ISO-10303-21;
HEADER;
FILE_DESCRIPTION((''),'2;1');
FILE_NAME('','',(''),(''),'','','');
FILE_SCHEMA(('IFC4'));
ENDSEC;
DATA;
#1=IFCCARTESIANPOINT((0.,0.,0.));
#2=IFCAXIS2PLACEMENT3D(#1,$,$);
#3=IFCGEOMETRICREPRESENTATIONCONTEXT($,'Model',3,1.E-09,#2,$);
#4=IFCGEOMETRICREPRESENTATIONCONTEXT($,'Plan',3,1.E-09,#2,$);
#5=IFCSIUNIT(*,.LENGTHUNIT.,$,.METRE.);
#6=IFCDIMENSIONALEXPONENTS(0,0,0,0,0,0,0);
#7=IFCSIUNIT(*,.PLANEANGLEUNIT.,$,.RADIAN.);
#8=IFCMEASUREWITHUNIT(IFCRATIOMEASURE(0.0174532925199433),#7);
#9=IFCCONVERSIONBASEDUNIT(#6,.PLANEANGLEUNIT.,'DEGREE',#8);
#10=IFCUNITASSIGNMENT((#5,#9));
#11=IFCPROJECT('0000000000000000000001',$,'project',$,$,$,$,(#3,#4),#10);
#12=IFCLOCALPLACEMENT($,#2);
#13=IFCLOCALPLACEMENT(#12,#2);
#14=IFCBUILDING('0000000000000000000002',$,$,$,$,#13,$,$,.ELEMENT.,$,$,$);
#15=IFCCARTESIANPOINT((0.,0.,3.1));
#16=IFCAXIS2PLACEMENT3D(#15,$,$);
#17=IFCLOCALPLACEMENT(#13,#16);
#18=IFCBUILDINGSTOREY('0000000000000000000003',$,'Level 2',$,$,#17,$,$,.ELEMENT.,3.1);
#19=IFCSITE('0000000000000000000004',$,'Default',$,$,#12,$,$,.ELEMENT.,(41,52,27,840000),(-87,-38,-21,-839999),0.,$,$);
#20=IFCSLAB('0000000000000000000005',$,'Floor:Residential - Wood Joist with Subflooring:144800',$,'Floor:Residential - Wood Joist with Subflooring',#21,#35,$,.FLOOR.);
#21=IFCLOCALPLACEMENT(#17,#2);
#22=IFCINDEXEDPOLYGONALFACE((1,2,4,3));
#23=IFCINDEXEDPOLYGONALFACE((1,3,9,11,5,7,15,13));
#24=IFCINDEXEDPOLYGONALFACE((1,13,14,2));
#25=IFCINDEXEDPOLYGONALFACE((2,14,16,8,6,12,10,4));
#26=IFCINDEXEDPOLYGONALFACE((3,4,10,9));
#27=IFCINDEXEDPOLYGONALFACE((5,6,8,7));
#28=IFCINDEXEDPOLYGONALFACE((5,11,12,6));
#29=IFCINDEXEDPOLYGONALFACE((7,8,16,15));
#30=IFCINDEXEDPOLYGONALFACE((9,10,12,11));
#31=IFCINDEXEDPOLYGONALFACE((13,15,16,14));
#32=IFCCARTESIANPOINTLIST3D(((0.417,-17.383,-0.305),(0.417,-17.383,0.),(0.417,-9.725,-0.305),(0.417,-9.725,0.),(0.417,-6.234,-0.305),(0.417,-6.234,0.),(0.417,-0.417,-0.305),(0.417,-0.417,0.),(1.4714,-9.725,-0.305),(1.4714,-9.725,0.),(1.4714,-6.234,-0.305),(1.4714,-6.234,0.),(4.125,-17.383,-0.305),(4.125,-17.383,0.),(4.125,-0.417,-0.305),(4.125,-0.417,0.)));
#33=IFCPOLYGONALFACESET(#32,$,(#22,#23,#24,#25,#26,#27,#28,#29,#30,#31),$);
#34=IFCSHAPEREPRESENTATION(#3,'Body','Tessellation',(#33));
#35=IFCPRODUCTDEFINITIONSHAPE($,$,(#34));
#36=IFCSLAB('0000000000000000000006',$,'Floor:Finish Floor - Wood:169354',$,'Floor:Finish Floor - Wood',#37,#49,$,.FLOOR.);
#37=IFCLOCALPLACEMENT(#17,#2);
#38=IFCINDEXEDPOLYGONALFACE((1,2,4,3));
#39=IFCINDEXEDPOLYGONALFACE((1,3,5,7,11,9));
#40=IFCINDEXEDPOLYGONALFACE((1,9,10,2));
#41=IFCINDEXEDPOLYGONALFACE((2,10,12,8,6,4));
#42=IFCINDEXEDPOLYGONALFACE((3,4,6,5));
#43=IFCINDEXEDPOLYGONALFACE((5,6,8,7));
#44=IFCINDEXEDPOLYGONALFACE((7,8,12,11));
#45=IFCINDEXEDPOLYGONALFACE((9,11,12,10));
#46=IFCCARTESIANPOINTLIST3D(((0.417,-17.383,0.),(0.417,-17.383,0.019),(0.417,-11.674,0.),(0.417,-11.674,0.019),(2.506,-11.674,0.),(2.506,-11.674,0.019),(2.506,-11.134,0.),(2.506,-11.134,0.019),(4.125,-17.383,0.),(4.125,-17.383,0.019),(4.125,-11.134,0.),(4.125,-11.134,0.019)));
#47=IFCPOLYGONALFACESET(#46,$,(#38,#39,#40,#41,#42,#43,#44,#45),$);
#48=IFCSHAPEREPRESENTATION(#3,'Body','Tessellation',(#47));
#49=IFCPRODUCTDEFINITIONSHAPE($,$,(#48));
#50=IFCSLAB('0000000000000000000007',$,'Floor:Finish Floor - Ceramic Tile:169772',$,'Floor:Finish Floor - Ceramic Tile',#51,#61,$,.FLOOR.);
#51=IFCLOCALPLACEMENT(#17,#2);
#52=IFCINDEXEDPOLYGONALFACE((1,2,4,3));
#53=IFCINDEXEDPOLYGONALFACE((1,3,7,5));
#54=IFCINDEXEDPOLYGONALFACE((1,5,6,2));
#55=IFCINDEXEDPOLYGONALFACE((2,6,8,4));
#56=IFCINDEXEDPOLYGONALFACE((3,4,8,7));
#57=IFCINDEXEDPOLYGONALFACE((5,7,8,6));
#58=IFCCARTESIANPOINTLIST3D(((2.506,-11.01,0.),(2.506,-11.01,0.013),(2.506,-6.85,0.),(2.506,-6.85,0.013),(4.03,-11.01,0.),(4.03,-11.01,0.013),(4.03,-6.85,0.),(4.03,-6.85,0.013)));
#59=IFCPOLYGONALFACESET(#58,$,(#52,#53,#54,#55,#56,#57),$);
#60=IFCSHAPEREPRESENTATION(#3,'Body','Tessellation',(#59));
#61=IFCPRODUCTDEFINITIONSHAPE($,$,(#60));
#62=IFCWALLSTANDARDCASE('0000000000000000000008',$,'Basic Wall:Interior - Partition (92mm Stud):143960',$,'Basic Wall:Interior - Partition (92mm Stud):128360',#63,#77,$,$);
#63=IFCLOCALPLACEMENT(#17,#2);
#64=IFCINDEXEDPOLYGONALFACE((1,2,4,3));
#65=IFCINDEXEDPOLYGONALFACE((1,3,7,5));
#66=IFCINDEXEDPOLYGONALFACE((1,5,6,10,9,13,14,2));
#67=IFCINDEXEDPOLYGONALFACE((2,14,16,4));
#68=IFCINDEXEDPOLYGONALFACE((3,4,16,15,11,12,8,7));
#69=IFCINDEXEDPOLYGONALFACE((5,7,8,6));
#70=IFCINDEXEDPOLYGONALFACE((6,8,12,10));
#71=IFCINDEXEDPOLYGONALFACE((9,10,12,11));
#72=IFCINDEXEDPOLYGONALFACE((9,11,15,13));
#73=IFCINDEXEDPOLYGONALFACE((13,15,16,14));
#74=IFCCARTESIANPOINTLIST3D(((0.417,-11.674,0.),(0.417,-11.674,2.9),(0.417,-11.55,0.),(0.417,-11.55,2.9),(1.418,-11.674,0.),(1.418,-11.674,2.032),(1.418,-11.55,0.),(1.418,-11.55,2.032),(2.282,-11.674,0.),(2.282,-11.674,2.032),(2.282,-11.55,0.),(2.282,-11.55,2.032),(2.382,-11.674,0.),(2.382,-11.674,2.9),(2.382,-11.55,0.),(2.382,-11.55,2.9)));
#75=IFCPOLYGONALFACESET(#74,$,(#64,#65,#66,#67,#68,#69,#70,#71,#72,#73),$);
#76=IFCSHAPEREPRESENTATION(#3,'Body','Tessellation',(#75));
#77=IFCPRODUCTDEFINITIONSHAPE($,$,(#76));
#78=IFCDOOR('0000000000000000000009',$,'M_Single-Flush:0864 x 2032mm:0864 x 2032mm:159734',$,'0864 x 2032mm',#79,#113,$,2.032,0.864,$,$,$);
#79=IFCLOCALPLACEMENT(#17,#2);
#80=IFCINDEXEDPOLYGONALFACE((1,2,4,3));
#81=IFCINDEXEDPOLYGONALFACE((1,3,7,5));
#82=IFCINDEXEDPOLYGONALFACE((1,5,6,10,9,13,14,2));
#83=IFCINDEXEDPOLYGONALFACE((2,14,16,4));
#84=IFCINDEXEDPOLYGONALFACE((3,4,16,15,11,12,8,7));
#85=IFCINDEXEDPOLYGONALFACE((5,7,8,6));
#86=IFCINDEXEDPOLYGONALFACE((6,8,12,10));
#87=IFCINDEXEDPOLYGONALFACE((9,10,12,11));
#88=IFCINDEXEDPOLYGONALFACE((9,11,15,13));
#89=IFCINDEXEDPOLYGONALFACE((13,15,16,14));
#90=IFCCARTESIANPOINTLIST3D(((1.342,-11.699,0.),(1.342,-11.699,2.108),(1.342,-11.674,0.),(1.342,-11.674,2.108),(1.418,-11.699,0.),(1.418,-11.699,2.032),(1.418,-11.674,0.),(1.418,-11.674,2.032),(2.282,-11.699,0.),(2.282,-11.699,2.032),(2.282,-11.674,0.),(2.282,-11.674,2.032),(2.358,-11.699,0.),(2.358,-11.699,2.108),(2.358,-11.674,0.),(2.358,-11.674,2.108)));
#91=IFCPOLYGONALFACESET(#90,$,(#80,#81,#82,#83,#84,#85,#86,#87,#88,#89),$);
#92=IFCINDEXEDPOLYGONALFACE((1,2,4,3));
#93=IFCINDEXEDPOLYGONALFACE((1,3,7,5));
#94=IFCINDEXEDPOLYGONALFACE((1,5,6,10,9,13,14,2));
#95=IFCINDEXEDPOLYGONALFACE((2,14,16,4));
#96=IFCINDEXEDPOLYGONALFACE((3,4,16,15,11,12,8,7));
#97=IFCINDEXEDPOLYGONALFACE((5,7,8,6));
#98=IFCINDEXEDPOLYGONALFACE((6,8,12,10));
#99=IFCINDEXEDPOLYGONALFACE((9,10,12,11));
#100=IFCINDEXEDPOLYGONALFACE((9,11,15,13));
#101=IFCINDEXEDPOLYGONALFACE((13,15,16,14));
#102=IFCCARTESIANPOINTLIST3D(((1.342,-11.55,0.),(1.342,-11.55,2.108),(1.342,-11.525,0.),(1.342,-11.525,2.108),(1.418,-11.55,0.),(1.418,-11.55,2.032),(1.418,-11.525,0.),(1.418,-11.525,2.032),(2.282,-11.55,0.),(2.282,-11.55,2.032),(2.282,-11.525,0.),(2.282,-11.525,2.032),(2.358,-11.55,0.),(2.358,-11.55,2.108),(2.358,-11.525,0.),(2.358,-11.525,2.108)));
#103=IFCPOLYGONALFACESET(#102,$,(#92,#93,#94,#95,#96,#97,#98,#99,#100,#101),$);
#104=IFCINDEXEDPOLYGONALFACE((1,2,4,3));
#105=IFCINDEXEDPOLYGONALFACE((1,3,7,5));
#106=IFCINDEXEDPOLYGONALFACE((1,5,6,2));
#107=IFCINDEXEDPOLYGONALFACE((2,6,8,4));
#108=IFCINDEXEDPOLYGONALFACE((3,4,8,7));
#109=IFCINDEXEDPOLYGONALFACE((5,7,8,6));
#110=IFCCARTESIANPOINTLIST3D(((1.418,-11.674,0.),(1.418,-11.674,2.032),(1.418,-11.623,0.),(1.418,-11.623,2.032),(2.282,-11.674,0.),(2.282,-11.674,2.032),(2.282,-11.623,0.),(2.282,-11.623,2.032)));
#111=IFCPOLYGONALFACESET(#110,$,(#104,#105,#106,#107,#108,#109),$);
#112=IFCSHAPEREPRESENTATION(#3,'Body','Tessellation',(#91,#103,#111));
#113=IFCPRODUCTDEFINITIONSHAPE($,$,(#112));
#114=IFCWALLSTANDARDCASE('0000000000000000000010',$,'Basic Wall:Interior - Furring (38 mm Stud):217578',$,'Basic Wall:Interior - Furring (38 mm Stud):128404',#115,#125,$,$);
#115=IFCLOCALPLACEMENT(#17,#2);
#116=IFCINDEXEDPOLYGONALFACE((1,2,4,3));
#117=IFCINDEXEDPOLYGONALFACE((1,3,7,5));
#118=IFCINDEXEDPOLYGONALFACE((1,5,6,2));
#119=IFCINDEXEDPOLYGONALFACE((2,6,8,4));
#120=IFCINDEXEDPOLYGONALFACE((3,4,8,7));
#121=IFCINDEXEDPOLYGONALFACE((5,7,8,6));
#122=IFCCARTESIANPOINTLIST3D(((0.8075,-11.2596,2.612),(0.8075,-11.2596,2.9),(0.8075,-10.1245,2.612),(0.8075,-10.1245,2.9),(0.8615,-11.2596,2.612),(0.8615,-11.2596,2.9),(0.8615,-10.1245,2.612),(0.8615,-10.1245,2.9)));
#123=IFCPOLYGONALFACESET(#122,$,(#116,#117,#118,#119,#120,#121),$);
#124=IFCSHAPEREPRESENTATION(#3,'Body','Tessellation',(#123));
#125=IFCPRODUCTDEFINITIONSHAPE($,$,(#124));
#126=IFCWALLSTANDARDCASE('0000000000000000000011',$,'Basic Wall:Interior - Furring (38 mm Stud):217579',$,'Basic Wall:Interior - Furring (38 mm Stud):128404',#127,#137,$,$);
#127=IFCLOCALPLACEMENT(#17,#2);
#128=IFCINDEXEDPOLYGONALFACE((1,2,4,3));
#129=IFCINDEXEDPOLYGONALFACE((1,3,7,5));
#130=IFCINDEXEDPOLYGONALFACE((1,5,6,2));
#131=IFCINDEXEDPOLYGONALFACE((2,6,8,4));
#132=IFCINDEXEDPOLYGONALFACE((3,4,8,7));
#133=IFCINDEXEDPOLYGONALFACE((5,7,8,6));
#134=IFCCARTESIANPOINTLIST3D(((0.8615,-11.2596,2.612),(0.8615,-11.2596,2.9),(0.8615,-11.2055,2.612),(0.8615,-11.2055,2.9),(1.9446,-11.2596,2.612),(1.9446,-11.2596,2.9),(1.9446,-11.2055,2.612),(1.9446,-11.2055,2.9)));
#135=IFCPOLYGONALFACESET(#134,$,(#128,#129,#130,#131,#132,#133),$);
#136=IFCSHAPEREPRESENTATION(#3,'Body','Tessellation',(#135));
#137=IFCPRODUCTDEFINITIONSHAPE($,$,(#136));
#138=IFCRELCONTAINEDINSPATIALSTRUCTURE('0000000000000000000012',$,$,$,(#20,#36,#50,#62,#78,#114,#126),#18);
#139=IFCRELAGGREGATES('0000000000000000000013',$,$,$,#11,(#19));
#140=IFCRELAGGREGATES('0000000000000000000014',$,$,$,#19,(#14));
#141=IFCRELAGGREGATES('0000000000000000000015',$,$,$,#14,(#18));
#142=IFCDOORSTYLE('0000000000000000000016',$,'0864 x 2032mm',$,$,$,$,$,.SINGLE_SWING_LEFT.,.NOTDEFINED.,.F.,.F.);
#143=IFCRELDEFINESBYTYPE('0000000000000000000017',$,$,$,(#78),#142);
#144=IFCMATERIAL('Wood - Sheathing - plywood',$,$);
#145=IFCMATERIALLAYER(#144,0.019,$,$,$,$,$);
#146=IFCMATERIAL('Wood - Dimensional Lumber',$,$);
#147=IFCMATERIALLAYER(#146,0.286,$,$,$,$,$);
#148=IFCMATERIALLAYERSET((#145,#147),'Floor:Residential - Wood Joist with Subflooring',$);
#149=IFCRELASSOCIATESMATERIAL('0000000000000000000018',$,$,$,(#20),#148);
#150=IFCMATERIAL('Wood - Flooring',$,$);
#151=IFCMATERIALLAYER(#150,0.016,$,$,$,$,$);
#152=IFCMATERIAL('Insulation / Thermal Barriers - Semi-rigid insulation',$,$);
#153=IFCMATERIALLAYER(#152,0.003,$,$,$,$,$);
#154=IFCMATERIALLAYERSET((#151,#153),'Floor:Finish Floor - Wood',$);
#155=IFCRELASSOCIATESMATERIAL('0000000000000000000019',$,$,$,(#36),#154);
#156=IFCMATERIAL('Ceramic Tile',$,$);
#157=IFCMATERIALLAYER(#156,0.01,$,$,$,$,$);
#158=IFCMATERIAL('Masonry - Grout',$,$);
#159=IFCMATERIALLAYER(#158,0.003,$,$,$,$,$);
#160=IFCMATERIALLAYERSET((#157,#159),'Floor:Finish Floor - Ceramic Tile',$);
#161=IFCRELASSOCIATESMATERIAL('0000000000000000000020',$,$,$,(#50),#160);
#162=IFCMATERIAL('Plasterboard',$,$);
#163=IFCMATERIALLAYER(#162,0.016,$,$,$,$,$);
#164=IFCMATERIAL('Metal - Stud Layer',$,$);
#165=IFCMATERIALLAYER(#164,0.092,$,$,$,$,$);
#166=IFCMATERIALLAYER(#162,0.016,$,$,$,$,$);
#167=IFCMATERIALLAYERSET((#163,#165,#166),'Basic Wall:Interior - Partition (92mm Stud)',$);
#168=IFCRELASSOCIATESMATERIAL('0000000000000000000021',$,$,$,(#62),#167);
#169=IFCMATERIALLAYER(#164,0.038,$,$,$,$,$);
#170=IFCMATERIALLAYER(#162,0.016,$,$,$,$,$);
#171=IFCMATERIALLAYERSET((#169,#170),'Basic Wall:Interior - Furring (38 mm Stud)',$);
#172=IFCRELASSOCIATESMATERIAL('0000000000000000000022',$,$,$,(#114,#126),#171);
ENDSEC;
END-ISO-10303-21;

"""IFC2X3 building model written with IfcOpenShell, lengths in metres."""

from ifc_helpers import new_model, entity, si_unit, converted_unit, frame, frame_2d, origin, origin_2d_with_axis, place, context, project, spatial, polyline, rectangle, outline, extrude, source, transform, mapped, material, layer, layer_set, layer_usage, type_object, type_shapes, element, fill, save


model = new_model("IFC2X3")

# Units and contexts
model_context = context("Model", 3, precision=1e-09, world=origin())
plan_context = context("Plan", 3, precision=1e-09, world=origin())
ifc_project = project(units=[si_unit("LENGTHUNIT", "METRE"), converted_unit("PLANEANGLEUNIT", "DEGREE", entity("IfcRatioMeasure", 0.0174532925199433), si_unit("PLANEANGLEUNIT", "RADIAN"), dimensions=[0, 0, 0, 0, 0, 0, 0])], contexts=[model_context, plan_context])

# Site, building, storey
site_placement = place(None, origin())
site = spatial("IfcSite", under=ifc_project, at=site_placement, Name="Default", CompositionType="ELEMENT", RefLatitude=(41, 52, 27, 840000), RefLongitude=(-87, -38, -21, -839999), RefElevation=0.0)
building_placement = place(site_placement, origin())
building = spatial("IfcBuilding", under=site, at=building_placement, CompositionType="ELEMENT")
storey_placement = place(building_placement, frame((0.0, 0.0, 3.1)))
storey = spatial("IfcBuildingStorey", under=building, at=storey_placement, Name="Level 2", CompositionType="ELEMENT", Elevation=3.1)

# Slabs
ifc_material_1 = material(Name="Wood - Sheathing - plywood")
ifc_layer_1 = layer(ifc_material_1, 0.019)
ifc_material_2 = material(Name="Wood - Dimensional Lumber")
ifc_layer_2 = layer(ifc_material_2, 0.286)
ifc_layer_set_1 = layer_set([ifc_layer_1, ifc_layer_2], Name="Floor:Residential - Wood Joist with Subflooring")
ifc_layer_usage_1 = layer_usage(ifc_layer_set_1, "AXIS3", "POSITIVE", 0.0)
slab_1_placement = place(storey_placement, frame((0.417, -17.383, -0.305)))
element("IfcSlab", 1, at=slab_1_placement, inside=storey, material=ifc_layer_usage_1, Name="Floor:Residential - Wood Joist with Subflooring:144800", ObjectType="Floor:Residential - Wood Joist with Subflooring", PredefinedType="FLOOR", context=model_context, shape_type="SweptSolid", body=[
    extrude(outline(polyline([(-1.854, 8.483), (-1.854, -8.483), (1.854, -8.483), (1.854, -0.825), (0.7996, -0.825), (0.7996, 2.666), (1.854, 2.666), (1.854, 8.483), (-1.854, 8.483)])), frame((1.854, 8.483, 0.305), z_axis=(0.0, 0.0, -1.0), x_axis=(-1.0, 0.0, 0.0)), (0.0, 0.0, 1.0), 0.305),
])
ifc_material_3 = material(Name="Wood - Flooring")
ifc_layer_3 = layer(ifc_material_3, 0.016)
ifc_material_4 = material(Name="Insulation / Thermal Barriers - Semi-rigid insulation")
ifc_layer_4 = layer(ifc_material_4, 0.003)
ifc_layer_set_2 = layer_set([ifc_layer_3, ifc_layer_4], Name="Floor:Finish Floor - Wood")
ifc_layer_usage_2 = layer_usage(ifc_layer_set_2, "AXIS3", "POSITIVE", 0.0)
slab_2_placement = place(storey_placement, frame((0.417, -17.383, 0.0)))
element("IfcSlab", 2, at=slab_2_placement, inside=storey, material=ifc_layer_usage_2, Name="Floor:Finish Floor - Wood:169354", ObjectType="Floor:Finish Floor - Wood", PredefinedType="FLOOR", context=model_context, shape_type="SweptSolid", body=[
    extrude(outline(polyline([(-1.854, -3.1245), (1.854, -3.1245), (1.854, 2.5845), (-0.235, 2.5845), (-0.235, 3.1245), (-1.854, 3.1245), (-1.854, -3.1245)])), frame((1.854, 3.1245, 0.019), z_axis=(0.0, 0.0, -1.0), x_axis=(-1.0, 0.0, 0.0)), (0.0, 0.0, 1.0), 0.019),
])
ifc_material_5 = material(Name="Ceramic Tile")
ifc_layer_5 = layer(ifc_material_5, 0.01)
ifc_material_6 = material(Name="Masonry - Grout")
ifc_layer_6 = layer(ifc_material_6, 0.003)
ifc_layer_set_3 = layer_set([ifc_layer_5, ifc_layer_6], Name="Floor:Finish Floor - Ceramic Tile")
ifc_layer_usage_3 = layer_usage(ifc_layer_set_3, "AXIS3", "POSITIVE", 0.0)
slab_3_placement = place(storey_placement, frame((2.506, -11.01, 0.0)))
element("IfcSlab", 3, at=slab_3_placement, inside=storey, material=ifc_layer_usage_3, Name="Floor:Finish Floor - Ceramic Tile:169772", ObjectType="Floor:Finish Floor - Ceramic Tile", PredefinedType="FLOOR", context=model_context, shape_type="SweptSolid", body=[
    extrude(rectangle(XDim=4.16, YDim=1.524, at=frame_2d((0.0, 0.0), x_axis=(0.0, -1.0))), frame((0.762, 2.08, 0.013), z_axis=(0.0, 0.0, -1.0), x_axis=(-1.0, 0.0, 0.0)), (0.0, 0.0, 1.0), 0.013),
])

# Shared definitions
ifc_material_7 = material(Name="Metal - Stud Layer")
ifc_material_8 = material(Name="Plasterboard")

# Wall, opening, door
ifc_layer_7 = layer(ifc_material_8, 0.016)
ifc_layer_8 = layer(ifc_material_7, 0.092)
ifc_layer_9 = layer(ifc_material_8, 0.016)
ifc_layer_set_4 = layer_set([ifc_layer_7, ifc_layer_8, ifc_layer_9], Name="Basic Wall:Interior - Partition (92mm Stud)")
ifc_layer_usage_4 = layer_usage(ifc_layer_set_4, "AXIS2", "NEGATIVE", 0.062)
wall_1_placement = place(storey_placement, frame((2.382, -11.612, 0.0), z_axis=(0.0, 0.0, 1.0), x_axis=(-1.0, 0.0, 0.0)))
wall_1 = element("IfcWallStandardCase", 4, at=wall_1_placement, inside=storey, material=ifc_layer_usage_4, Name="Basic Wall:Interior - Partition (92mm Stud):143960", ObjectType="Basic Wall:Interior - Partition (92mm Stud):128360", context=model_context, shape_type="SweptSolid", body=[
    extrude(rectangle(XDim=1.965, YDim=0.124, at=frame_2d((0.9825, 0.0), x_axis=(-1.0, 0.0))), origin(), (0.0, 0.0, 1.0), 2.9),
])
opening_1_placement = place(wall_1_placement, frame((0.1, -0.062, 0.0)))
opening_1 = element("IfcOpeningElement", 5, at=opening_1_placement, cuts=wall_1, ObjectType="Opening", context=model_context, shape_type="SweptSolid", body=[
    extrude(rectangle(XDim=0.864, YDim=2.032, at=frame_2d((1.016, 0.432), x_axis=(0.0, -1.0))), frame((0.0, 0.0, 0.0), z_axis=(0.0, 1.0, 0.0), x_axis=(0.0, 0.0, 1.0)), (0.0, 0.0, 1.0), 0.124),
])
door_style = type_object("IfcDoorStyle", Name="0864 x 2032mm", ConstructionType="NOTDEFINED", OperationType="SINGLE_SWING_LEFT", ParameterTakesPrecedence=False, Sizeable=False)
shared_shape_1 = source(origin(), model_context, "Body", "SweptSolid", [
    extrude(outline(polyline([(-0.508, -1.073), (0.508, -1.073), (0.508, 1.035), (0.432, 1.035), (0.432, -0.997), (-0.432, -0.997), (-0.432, 1.035), (-0.508, 1.035), (-0.508, -1.073)])), frame((0.432, 0.149, 1.035), z_axis=(0.0, -1.0, 0.0), x_axis=(-1.0, 0.0, 0.0)), (0.0, 0.0, 1.0), 0.025),
    extrude(outline(polyline([(-1.073, -0.508), (1.035, -0.508), (1.035, -0.432), (-0.997, -0.432), (-0.997, 0.432), (1.035, 0.432), (1.035, 0.508), (-1.073, 0.508), (-1.073, -0.508)])), frame((0.432, 0.0, 1.035), z_axis=(0.0, -1.0, 0.0), x_axis=(0.0, 0.0, -1.0)), (0.0, 0.0, 1.0), 0.025),
    extrude(rectangle(XDim=0.864, YDim=0.051, at=origin_2d_with_axis()), frame((0.432, 0.0985, 0.0)), (0.0, 0.0, 1.0), 2.032),
])
type_shapes(door_style, [shared_shape_1])
door_placement = place(opening_1_placement, origin())
door = element("IfcDoor", 6, at=door_placement, inside=storey, type_object=door_style, Name="M_Single-Flush:0864 x 2032mm:0864 x 2032mm:159734", ObjectType="0864 x 2032mm", OverallHeight=2.032, OverallWidth=0.864, context=model_context, shape_type="MappedRepresentation", body=[
    mapped(shared_shape_1, transform((0.0, 0.0, 0.0), scale=1.0)),
])
fill(opening_1, door)

# Walls
ifc_layer_10 = layer(ifc_material_7, 0.038)
ifc_layer_11 = layer(ifc_material_8, 0.016)
ifc_layer_set_5 = layer_set([ifc_layer_10, ifc_layer_11], Name="Basic Wall:Interior - Furring (38 mm Stud)")
ifc_layer_usage_5 = layer_usage(ifc_layer_set_5, "AXIS2", "NEGATIVE", 0.027)
wall_2_placement = place(storey_placement, frame((0.8345, -11.2596, 2.612), z_axis=(0.0, 0.0, 1.0), x_axis=(0.0, 1.0, 0.0)))
element("IfcWallStandardCase", 7, at=wall_2_placement, inside=storey, material=ifc_layer_usage_5, Name="Basic Wall:Interior - Furring (38 mm Stud):217578", ObjectType="Basic Wall:Interior - Furring (38 mm Stud):128404", context=model_context, shape_type="SweptSolid", body=[
    extrude(rectangle(XDim=1.1351, YDim=0.054, at=frame_2d((0.5675, 0.0), x_axis=(-1.0, 0.0))), origin(), (0.0, 0.0, 1.0), 0.288),
])
ifc_layer_usage_6 = layer_usage(ifc_layer_set_5, "AXIS2", "NEGATIVE", 0.027)
wall_3_placement = place(storey_placement, frame((1.9446, -11.2325, 2.612), z_axis=(0.0, 0.0, 1.0), x_axis=(-1.0, 0.0, 0.0)))
element("IfcWallStandardCase", 8, at=wall_3_placement, inside=storey, material=ifc_layer_usage_6, Name="Basic Wall:Interior - Furring (38 mm Stud):217579", ObjectType="Basic Wall:Interior - Furring (38 mm Stud):128404", context=model_context, shape_type="SweptSolid", body=[
    extrude(rectangle(XDim=1.0831, YDim=0.054, at=frame_2d((0.5415, 0.0), x_axis=(-1.0, 0.0))), origin(), (0.0, 0.0, 1.0), 0.288),
])

save(model, "model.ifc")
